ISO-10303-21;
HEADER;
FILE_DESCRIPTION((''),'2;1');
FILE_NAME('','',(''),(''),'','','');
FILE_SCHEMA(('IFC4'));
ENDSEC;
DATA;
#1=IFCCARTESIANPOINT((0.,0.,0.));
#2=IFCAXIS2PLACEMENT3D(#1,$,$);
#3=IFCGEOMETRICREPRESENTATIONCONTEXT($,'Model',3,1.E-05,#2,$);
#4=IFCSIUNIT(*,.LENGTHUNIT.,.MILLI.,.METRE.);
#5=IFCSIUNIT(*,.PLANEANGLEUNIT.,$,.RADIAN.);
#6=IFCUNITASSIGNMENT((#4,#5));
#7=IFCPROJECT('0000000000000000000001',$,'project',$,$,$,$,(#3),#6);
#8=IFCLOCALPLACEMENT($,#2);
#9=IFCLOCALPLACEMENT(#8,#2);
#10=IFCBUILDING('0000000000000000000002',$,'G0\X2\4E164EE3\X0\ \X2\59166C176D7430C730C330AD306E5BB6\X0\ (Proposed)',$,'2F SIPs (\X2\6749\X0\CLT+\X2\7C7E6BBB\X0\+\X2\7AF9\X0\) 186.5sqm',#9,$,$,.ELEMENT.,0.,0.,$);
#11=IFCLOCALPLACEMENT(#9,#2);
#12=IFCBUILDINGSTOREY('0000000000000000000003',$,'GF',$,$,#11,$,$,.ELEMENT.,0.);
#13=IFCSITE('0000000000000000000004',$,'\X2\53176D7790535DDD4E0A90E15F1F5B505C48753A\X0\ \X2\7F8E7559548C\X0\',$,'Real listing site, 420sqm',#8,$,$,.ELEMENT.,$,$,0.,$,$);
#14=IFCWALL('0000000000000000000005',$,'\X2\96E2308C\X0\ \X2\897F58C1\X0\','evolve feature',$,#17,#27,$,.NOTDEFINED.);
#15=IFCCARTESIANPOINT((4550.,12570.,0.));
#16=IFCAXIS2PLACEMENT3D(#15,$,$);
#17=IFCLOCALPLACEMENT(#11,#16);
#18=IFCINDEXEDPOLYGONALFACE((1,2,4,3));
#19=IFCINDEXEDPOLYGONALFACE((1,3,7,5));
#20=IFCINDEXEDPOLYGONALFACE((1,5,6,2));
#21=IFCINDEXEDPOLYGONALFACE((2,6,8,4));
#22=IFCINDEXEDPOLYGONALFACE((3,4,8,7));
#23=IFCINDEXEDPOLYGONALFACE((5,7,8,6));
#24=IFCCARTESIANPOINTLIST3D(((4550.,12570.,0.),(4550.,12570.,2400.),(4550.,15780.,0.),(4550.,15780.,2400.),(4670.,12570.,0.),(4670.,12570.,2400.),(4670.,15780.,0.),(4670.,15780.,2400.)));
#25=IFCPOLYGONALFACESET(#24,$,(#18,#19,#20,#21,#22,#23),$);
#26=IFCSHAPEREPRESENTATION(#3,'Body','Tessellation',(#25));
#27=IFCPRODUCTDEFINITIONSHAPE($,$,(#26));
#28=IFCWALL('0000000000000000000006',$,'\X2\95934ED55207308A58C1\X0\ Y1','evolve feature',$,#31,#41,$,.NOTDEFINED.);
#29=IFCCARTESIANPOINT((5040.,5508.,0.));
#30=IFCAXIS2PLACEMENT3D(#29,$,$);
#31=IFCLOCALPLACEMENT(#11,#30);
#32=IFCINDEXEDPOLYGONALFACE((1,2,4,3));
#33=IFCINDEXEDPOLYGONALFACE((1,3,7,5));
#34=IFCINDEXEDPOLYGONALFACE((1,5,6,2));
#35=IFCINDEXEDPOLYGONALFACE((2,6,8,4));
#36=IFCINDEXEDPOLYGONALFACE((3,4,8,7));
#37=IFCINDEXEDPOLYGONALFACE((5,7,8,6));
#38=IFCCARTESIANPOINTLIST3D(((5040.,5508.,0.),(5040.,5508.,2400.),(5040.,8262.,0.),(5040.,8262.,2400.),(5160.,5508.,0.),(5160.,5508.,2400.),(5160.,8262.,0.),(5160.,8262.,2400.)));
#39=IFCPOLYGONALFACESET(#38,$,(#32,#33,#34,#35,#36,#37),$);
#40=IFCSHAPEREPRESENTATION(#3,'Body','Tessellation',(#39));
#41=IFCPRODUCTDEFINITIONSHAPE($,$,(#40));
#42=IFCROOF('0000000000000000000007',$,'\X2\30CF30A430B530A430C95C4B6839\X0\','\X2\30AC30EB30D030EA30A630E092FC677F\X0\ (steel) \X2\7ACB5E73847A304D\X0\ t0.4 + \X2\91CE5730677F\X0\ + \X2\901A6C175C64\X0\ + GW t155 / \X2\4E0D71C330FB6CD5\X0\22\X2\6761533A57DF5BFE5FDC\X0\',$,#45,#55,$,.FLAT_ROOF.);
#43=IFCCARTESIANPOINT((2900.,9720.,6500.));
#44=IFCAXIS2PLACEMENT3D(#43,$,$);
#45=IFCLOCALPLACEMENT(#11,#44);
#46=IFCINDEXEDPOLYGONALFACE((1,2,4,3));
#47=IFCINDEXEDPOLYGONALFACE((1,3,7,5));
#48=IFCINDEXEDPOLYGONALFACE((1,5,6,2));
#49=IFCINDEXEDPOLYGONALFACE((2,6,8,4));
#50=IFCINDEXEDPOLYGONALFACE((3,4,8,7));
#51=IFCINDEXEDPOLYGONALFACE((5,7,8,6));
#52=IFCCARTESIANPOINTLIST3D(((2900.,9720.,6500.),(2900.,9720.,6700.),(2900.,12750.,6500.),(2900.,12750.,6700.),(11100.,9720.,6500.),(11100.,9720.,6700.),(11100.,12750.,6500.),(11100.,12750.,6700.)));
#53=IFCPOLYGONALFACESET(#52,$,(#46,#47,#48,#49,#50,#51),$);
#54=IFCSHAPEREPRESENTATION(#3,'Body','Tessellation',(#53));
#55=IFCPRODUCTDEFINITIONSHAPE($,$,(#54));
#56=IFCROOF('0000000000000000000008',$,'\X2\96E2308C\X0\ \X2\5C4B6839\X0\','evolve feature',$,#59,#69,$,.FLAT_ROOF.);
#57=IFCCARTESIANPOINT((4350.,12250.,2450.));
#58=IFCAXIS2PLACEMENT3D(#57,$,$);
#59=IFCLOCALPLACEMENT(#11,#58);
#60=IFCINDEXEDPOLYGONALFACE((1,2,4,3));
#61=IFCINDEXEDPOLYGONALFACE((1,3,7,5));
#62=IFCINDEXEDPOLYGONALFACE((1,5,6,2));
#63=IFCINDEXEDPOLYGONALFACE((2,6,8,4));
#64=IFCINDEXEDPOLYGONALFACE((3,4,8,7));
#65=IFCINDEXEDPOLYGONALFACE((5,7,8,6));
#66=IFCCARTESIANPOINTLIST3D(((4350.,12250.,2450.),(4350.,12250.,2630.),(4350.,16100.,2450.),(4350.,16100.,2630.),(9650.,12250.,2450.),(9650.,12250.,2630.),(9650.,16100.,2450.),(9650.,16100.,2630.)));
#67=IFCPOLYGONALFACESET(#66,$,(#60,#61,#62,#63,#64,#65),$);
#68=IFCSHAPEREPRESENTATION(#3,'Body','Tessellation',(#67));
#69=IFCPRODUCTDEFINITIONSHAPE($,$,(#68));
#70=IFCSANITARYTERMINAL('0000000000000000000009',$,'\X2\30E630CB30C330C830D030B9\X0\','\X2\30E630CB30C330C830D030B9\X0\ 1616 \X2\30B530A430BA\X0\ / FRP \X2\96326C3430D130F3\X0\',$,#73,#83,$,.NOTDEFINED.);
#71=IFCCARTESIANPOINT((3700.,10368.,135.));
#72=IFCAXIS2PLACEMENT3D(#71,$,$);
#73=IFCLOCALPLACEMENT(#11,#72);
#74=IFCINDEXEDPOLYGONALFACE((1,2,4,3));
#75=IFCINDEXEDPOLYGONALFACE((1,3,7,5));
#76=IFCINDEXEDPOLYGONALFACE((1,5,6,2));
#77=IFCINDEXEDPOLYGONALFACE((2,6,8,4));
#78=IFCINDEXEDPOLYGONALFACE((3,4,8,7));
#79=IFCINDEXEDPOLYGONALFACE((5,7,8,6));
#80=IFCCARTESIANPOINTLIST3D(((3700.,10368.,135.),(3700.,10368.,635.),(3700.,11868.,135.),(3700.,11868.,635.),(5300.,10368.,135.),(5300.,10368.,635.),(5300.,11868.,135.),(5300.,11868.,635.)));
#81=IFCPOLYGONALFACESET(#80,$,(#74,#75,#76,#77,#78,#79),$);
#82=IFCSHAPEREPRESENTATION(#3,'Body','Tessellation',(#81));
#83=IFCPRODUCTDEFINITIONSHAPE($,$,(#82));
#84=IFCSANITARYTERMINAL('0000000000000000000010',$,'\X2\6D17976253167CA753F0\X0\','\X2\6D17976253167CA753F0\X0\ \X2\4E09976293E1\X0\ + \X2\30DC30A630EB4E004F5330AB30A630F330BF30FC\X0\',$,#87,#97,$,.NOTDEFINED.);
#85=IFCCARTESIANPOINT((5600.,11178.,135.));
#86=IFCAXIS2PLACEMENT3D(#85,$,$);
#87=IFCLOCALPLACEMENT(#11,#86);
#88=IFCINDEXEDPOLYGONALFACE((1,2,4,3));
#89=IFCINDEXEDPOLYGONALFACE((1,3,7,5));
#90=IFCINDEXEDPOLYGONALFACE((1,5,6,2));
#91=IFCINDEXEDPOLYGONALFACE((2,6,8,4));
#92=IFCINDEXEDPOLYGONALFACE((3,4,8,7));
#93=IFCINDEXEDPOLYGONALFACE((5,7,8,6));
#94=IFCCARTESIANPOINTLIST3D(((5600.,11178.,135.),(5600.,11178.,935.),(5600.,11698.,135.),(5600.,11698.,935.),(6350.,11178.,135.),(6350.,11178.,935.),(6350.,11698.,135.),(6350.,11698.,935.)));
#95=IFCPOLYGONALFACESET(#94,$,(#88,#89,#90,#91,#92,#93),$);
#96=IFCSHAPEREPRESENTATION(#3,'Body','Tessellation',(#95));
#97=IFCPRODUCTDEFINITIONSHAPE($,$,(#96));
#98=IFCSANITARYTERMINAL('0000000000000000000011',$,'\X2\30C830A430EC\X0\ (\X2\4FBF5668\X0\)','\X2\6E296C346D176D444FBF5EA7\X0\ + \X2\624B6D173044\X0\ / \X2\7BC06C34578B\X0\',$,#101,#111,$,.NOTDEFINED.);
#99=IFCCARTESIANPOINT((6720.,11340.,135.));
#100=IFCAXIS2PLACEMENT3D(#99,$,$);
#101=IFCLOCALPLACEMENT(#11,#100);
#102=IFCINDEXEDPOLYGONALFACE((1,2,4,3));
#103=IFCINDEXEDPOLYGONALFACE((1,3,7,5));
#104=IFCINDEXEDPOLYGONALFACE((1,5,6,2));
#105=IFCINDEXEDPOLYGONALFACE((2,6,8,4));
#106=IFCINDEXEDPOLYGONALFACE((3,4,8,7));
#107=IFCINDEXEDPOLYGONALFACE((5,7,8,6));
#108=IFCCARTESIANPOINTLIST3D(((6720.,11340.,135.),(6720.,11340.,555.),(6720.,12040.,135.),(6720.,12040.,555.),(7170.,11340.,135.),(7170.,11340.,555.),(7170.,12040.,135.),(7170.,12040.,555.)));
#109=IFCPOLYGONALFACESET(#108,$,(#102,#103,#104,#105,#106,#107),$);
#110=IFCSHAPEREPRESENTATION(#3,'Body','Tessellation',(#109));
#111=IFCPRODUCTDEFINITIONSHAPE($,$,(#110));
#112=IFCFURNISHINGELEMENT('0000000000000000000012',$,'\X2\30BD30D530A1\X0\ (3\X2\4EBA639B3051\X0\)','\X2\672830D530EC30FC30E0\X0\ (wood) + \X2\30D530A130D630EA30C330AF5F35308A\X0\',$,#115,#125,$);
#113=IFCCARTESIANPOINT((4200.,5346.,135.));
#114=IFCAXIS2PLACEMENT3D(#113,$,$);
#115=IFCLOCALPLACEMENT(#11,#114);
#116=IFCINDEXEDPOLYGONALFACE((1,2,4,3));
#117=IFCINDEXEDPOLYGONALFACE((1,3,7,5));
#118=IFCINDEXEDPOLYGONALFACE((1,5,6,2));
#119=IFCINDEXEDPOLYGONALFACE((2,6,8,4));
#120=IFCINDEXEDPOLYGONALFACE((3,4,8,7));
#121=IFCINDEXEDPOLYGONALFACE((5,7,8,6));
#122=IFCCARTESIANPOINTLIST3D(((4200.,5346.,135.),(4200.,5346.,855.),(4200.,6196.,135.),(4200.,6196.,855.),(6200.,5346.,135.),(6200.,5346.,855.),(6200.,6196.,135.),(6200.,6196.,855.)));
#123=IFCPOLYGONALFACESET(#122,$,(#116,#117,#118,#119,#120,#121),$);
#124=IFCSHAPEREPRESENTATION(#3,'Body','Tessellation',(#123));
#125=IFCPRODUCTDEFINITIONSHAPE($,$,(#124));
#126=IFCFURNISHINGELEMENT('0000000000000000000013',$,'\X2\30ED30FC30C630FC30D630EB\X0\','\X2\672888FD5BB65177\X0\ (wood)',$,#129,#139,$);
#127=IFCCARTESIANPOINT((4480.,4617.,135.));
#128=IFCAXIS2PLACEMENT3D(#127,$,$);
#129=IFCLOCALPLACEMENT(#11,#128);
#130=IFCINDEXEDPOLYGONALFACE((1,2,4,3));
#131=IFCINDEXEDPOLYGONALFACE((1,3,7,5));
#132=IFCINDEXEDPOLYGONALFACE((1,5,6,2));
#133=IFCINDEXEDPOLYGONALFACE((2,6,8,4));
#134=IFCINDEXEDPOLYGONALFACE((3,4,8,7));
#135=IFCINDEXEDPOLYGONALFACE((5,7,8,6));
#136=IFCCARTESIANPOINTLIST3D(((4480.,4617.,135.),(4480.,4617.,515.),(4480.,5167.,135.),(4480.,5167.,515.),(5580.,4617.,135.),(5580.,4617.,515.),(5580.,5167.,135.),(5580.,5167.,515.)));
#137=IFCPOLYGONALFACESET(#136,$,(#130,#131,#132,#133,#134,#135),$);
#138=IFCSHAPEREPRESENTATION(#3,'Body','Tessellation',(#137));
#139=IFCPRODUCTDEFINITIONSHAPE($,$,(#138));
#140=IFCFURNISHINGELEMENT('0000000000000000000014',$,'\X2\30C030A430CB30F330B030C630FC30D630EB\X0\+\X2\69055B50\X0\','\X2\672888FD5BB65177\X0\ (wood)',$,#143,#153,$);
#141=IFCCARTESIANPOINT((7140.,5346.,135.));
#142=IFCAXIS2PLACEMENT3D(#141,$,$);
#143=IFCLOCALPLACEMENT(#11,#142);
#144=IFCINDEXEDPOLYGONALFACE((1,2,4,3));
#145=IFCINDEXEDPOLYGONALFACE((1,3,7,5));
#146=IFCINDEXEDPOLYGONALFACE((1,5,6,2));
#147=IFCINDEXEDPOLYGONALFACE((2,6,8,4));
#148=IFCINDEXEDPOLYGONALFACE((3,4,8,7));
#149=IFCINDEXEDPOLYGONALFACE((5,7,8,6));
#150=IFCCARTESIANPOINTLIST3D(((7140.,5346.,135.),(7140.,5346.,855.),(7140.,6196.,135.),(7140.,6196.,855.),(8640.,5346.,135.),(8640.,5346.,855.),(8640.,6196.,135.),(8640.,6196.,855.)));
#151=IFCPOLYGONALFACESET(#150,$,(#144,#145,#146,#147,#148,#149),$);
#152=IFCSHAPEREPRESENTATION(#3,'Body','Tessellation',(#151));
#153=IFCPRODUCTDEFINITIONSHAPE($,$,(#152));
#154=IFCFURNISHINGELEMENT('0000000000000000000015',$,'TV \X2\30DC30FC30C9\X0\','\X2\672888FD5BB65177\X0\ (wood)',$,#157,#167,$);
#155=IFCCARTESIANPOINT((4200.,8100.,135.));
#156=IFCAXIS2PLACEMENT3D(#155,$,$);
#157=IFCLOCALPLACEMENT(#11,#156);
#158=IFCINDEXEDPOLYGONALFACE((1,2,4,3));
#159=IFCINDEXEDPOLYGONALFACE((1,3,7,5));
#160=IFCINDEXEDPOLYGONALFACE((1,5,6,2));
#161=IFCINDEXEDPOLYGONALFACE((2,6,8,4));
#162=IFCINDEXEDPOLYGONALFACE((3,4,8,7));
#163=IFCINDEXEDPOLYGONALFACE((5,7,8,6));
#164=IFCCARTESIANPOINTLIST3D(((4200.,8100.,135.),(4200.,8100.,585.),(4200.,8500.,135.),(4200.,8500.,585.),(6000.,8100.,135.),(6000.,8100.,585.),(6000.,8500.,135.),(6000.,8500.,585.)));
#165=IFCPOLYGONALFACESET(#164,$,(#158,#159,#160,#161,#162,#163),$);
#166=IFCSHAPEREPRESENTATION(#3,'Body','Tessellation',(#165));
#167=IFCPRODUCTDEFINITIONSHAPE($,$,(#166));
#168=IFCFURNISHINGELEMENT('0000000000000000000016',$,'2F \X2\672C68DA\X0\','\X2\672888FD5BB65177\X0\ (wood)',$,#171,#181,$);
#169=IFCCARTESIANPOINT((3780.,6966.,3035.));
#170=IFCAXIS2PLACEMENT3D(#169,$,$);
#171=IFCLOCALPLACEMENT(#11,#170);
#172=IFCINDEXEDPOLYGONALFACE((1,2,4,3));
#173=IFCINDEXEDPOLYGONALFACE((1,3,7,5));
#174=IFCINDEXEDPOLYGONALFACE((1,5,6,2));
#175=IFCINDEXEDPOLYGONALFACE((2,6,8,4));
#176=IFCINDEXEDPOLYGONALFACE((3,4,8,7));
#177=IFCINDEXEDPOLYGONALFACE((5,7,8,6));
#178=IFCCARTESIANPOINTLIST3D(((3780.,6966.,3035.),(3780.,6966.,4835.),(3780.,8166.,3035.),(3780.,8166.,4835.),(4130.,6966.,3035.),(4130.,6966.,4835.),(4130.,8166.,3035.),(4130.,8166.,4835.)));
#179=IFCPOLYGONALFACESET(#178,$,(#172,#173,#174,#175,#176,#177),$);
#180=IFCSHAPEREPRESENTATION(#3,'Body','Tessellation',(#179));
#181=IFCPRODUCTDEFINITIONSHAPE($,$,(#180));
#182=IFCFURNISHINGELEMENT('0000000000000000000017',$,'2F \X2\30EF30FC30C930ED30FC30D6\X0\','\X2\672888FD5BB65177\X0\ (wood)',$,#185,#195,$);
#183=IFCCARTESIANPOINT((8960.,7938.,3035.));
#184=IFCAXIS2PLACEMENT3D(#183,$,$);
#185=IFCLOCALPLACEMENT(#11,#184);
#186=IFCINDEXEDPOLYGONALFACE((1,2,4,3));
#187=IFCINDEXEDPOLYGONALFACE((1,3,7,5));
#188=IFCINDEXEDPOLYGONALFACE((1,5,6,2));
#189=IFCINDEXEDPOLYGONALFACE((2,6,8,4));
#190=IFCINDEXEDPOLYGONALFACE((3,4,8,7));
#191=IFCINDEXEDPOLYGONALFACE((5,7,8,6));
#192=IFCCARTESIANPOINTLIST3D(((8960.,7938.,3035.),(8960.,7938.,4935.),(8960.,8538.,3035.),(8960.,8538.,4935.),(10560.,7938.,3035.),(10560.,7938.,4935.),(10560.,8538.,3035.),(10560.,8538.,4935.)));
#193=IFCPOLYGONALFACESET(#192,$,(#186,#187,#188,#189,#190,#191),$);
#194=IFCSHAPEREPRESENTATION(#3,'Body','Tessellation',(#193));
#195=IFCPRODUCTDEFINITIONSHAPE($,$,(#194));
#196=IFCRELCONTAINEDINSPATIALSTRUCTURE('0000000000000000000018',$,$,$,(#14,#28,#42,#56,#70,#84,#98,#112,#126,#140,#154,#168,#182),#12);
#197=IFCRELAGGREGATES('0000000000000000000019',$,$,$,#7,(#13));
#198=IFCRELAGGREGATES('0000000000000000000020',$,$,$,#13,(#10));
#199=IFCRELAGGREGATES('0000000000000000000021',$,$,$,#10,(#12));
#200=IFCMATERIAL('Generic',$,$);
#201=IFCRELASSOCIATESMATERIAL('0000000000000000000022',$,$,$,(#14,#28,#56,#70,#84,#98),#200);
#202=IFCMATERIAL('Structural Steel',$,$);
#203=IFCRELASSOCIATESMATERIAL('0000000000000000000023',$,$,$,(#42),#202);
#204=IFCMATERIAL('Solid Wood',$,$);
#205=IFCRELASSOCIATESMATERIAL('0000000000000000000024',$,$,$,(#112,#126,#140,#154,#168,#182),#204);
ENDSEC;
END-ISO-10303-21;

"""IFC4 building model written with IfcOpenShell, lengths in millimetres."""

from ifc_helpers import new_model, si_unit, frame, frame_2d, origin, place, context, project, spatial, rectangle, extrude, material, element, save


model = new_model("IFC4")

# Units and contexts
model_context = context("Model", 3, precision=1e-05, world=origin())
ifc_project = project(units=[si_unit("LENGTHUNIT", "METRE", prefix="MILLI"), si_unit("PLANEANGLEUNIT", "RADIAN")], contexts=[model_context])

# Site, building, storey
site_placement = place(None, origin())
site = spatial("IfcSite", under=ifc_project, at=site_placement, Name="北海道川上郡弟子屈町 美留和", ObjectType="Real listing site, 420sqm", CompositionType="ELEMENT", RefElevation=0.0)
building_placement = place(site_placement, origin())
building = spatial("IfcBuilding", under=site, at=building_placement, Name="G0世代 外気浴デッキの家 (Proposed)", ObjectType="2F SIPs (杉CLT+籾殻+竹) 186.5sqm", CompositionType="ELEMENT", ElevationOfRefHeight=0.0, ElevationOfTerrain=0.0)
storey_placement = place(building_placement, origin())
storey = spatial("IfcBuildingStorey", under=building, at=storey_placement, Name="GF", CompositionType="ELEMENT", Elevation=0.0)

# Shared definitions
ifc_material_1 = material(Name="Generic")

# Shared definitions
ifc_material_2 = material(Name="Solid Wood")

# Walls
wall_1_placement = place(storey_placement, frame((4550.0, 12570.0, 0.0)))
element("IfcWall", 1, at=wall_1_placement, inside=storey, material=ifc_material_1, Name="離れ 西壁", Description="evolve feature", PredefinedType="NOTDEFINED", context=model_context, shape_type="SweptSolid", body=[
    extrude(rectangle(XDim=120.0, YDim=3210.0, at=frame_2d((60.0, 1605.0))), frame((4550.0, 12570.0, 0.0)), (0.0, 0.0, 1.0), 2400.0),
])
wall_2_placement = place(storey_placement, frame((5040.0, 5508.0, 0.0)))
element("IfcWall", 2, at=wall_2_placement, inside=storey, material=ifc_material_1, Name="間仕切り壁 Y1", Description="evolve feature", PredefinedType="NOTDEFINED", context=model_context, shape_type="SweptSolid", body=[
    extrude(rectangle(XDim=120.0, YDim=2754.0, at=frame_2d((60.0, 1377.0))), frame((5040.0, 5508.0, 0.0)), (0.0, 0.0, 1.0), 2400.0),
])

# Roofs
ifc_material_3 = material(Name="Structural Steel")
roof_1_placement = place(storey_placement, frame((2900.0, 9720.0, 6500.0)))
element("IfcRoof", 3, at=roof_1_placement, inside=storey, material=ifc_material_3, Name="ハイサイド屋根", Description="ガルバリウム鋼板 (steel) 立平葺き t0.4 + 野地板 + 通気層 + GW t155 / 不燃・法22条区域対応", PredefinedType="FLAT_ROOF", context=model_context, shape_type="SweptSolid", body=[
    extrude(rectangle(XDim=8200.0, YDim=3030.0, at=frame_2d((4100.0, 1515.0))), frame((2900.0, 9720.0, 6500.0)), (0.0, 0.0, 1.0), 200.0),
])
roof_2_placement = place(storey_placement, frame((4350.0, 12250.0, 2450.0)))
element("IfcRoof", 4, at=roof_2_placement, inside=storey, material=ifc_material_1, Name="離れ 屋根", Description="evolve feature", PredefinedType="FLAT_ROOF", context=model_context, shape_type="SweptSolid", body=[
    extrude(rectangle(XDim=5300.0, YDim=3850.0, at=frame_2d((2650.0, 1925.0))), frame((4350.0, 12250.0, 2450.0)), (0.0, 0.0, 1.0), 180.0),
])

# Sanitary terminals
sanitary_terminal_1_placement = place(storey_placement, frame((3700.0, 10368.0, 135.0)))
element("IfcSanitaryTerminal", 5, at=sanitary_terminal_1_placement, inside=storey, material=ifc_material_1, Name="ユニットバス", Description="ユニットバス 1616 サイズ / FRP 防水パン", PredefinedType="NOTDEFINED", context=model_context, shape_type="SweptSolid", body=[
    extrude(rectangle(XDim=1600.0, YDim=1500.0, at=frame_2d((800.0, 750.0))), frame((3700.0, 10368.0, 135.0)), (0.0, 0.0, 1.0), 500.0),
])
sanitary_terminal_2_placement = place(storey_placement, frame((5600.0, 11178.0, 135.0)))
element("IfcSanitaryTerminal", 6, at=sanitary_terminal_2_placement, inside=storey, material=ifc_material_1, Name="洗面化粧台", Description="洗面化粧台 三面鏡 + ボウル一体カウンター", PredefinedType="NOTDEFINED", context=model_context, shape_type="SweptSolid", body=[
    extrude(rectangle(XDim=750.0, YDim=520.0, at=frame_2d((375.0, 260.0))), frame((5600.0, 11178.0, 135.0)), (0.0, 0.0, 1.0), 800.0),
])
sanitary_terminal_3_placement = place(storey_placement, frame((6720.0, 11340.0, 135.0)))
element("IfcSanitaryTerminal", 7, at=sanitary_terminal_3_placement, inside=storey, material=ifc_material_1, Name="トイレ (便器)", Description="温水洗浄便座 + 手洗い / 節水型", PredefinedType="NOTDEFINED", context=model_context, shape_type="SweptSolid", body=[
    extrude(rectangle(XDim=450.0, YDim=700.0, at=frame_2d((225.0, 350.0))), frame((6720.0, 11340.0, 135.0)), (0.0, 0.0, 1.0), 420.0),
])

# Furnishing elements
furnishing_1_placement = place(storey_placement, frame((4200.0, 5346.0, 135.0)))
element("IfcFurnishingElement", 8, at=furnishing_1_placement, inside=storey, material=ifc_material_2, Name="ソファ (3人掛け)", Description="木フレーム (wood) + ファブリック張り", context=model_context, shape_type="SweptSolid", body=[
    extrude(rectangle(XDim=2000.0, YDim=850.0, at=frame_2d((1000.0, 425.0))), frame((4200.0, 5346.0, 135.0)), (0.0, 0.0, 1.0), 720.0),
])
furnishing_2_placement = place(storey_placement, frame((4480.0, 4617.0, 135.0)))
element("IfcFurnishingElement", 9, at=furnishing_2_placement, inside=storey, material=ifc_material_2, Name="ローテーブル", Description="木製家具 (wood)", context=model_context, shape_type="SweptSolid", body=[
    extrude(rectangle(XDim=1100.0, YDim=550.0, at=frame_2d((550.0, 275.0))), frame((4480.0, 4617.0, 135.0)), (0.0, 0.0, 1.0), 380.0),
])
furnishing_3_placement = place(storey_placement, frame((7140.0, 5346.0, 135.0)))
element("IfcFurnishingElement", 10, at=furnishing_3_placement, inside=storey, material=ifc_material_2, Name="ダイニングテーブル+椅子", Description="木製家具 (wood)", context=model_context, shape_type="SweptSolid", body=[
    extrude(rectangle(XDim=1500.0, YDim=850.0, at=frame_2d((750.0, 425.0))), frame((7140.0, 5346.0, 135.0)), (0.0, 0.0, 1.0), 720.0),
])
furnishing_4_placement = place(storey_placement, frame((4200.0, 8100.0, 135.0)))
element("IfcFurnishingElement", 11, at=furnishing_4_placement, inside=storey, material=ifc_material_2, Name="TV ボード", Description="木製家具 (wood)", context=model_context, shape_type="SweptSolid", body=[
    extrude(rectangle(XDim=1800.0, YDim=400.0, at=frame_2d((900.0, 200.0))), frame((4200.0, 8100.0, 135.0)), (0.0, 0.0, 1.0), 450.0),
])
furnishing_5_placement = place(storey_placement, frame((3780.0, 6966.0, 3035.0)))
element("IfcFurnishingElement", 12, at=furnishing_5_placement, inside=storey, material=ifc_material_2, Name="2F 本棚", Description="木製家具 (wood)", context=model_context, shape_type="SweptSolid", body=[
    extrude(rectangle(XDim=350.0, YDim=1200.0, at=frame_2d((175.0, 600.0))), frame((3780.0, 6966.0, 3035.0)), (0.0, 0.0, 1.0), 1800.0),
])
furnishing_6_placement = place(storey_placement, frame((8960.0, 7938.0, 3035.0)))
element("IfcFurnishingElement", 13, at=furnishing_6_placement, inside=storey, material=ifc_material_2, Name="2F ワードローブ", Description="木製家具 (wood)", context=model_context, shape_type="SweptSolid", body=[
    extrude(rectangle(XDim=1600.0, YDim=600.0, at=frame_2d((800.0, 300.0))), frame((8960.0, 7938.0, 3035.0)), (0.0, 0.0, 1.0), 1900.0),
])

save(model, "model.ifc")
